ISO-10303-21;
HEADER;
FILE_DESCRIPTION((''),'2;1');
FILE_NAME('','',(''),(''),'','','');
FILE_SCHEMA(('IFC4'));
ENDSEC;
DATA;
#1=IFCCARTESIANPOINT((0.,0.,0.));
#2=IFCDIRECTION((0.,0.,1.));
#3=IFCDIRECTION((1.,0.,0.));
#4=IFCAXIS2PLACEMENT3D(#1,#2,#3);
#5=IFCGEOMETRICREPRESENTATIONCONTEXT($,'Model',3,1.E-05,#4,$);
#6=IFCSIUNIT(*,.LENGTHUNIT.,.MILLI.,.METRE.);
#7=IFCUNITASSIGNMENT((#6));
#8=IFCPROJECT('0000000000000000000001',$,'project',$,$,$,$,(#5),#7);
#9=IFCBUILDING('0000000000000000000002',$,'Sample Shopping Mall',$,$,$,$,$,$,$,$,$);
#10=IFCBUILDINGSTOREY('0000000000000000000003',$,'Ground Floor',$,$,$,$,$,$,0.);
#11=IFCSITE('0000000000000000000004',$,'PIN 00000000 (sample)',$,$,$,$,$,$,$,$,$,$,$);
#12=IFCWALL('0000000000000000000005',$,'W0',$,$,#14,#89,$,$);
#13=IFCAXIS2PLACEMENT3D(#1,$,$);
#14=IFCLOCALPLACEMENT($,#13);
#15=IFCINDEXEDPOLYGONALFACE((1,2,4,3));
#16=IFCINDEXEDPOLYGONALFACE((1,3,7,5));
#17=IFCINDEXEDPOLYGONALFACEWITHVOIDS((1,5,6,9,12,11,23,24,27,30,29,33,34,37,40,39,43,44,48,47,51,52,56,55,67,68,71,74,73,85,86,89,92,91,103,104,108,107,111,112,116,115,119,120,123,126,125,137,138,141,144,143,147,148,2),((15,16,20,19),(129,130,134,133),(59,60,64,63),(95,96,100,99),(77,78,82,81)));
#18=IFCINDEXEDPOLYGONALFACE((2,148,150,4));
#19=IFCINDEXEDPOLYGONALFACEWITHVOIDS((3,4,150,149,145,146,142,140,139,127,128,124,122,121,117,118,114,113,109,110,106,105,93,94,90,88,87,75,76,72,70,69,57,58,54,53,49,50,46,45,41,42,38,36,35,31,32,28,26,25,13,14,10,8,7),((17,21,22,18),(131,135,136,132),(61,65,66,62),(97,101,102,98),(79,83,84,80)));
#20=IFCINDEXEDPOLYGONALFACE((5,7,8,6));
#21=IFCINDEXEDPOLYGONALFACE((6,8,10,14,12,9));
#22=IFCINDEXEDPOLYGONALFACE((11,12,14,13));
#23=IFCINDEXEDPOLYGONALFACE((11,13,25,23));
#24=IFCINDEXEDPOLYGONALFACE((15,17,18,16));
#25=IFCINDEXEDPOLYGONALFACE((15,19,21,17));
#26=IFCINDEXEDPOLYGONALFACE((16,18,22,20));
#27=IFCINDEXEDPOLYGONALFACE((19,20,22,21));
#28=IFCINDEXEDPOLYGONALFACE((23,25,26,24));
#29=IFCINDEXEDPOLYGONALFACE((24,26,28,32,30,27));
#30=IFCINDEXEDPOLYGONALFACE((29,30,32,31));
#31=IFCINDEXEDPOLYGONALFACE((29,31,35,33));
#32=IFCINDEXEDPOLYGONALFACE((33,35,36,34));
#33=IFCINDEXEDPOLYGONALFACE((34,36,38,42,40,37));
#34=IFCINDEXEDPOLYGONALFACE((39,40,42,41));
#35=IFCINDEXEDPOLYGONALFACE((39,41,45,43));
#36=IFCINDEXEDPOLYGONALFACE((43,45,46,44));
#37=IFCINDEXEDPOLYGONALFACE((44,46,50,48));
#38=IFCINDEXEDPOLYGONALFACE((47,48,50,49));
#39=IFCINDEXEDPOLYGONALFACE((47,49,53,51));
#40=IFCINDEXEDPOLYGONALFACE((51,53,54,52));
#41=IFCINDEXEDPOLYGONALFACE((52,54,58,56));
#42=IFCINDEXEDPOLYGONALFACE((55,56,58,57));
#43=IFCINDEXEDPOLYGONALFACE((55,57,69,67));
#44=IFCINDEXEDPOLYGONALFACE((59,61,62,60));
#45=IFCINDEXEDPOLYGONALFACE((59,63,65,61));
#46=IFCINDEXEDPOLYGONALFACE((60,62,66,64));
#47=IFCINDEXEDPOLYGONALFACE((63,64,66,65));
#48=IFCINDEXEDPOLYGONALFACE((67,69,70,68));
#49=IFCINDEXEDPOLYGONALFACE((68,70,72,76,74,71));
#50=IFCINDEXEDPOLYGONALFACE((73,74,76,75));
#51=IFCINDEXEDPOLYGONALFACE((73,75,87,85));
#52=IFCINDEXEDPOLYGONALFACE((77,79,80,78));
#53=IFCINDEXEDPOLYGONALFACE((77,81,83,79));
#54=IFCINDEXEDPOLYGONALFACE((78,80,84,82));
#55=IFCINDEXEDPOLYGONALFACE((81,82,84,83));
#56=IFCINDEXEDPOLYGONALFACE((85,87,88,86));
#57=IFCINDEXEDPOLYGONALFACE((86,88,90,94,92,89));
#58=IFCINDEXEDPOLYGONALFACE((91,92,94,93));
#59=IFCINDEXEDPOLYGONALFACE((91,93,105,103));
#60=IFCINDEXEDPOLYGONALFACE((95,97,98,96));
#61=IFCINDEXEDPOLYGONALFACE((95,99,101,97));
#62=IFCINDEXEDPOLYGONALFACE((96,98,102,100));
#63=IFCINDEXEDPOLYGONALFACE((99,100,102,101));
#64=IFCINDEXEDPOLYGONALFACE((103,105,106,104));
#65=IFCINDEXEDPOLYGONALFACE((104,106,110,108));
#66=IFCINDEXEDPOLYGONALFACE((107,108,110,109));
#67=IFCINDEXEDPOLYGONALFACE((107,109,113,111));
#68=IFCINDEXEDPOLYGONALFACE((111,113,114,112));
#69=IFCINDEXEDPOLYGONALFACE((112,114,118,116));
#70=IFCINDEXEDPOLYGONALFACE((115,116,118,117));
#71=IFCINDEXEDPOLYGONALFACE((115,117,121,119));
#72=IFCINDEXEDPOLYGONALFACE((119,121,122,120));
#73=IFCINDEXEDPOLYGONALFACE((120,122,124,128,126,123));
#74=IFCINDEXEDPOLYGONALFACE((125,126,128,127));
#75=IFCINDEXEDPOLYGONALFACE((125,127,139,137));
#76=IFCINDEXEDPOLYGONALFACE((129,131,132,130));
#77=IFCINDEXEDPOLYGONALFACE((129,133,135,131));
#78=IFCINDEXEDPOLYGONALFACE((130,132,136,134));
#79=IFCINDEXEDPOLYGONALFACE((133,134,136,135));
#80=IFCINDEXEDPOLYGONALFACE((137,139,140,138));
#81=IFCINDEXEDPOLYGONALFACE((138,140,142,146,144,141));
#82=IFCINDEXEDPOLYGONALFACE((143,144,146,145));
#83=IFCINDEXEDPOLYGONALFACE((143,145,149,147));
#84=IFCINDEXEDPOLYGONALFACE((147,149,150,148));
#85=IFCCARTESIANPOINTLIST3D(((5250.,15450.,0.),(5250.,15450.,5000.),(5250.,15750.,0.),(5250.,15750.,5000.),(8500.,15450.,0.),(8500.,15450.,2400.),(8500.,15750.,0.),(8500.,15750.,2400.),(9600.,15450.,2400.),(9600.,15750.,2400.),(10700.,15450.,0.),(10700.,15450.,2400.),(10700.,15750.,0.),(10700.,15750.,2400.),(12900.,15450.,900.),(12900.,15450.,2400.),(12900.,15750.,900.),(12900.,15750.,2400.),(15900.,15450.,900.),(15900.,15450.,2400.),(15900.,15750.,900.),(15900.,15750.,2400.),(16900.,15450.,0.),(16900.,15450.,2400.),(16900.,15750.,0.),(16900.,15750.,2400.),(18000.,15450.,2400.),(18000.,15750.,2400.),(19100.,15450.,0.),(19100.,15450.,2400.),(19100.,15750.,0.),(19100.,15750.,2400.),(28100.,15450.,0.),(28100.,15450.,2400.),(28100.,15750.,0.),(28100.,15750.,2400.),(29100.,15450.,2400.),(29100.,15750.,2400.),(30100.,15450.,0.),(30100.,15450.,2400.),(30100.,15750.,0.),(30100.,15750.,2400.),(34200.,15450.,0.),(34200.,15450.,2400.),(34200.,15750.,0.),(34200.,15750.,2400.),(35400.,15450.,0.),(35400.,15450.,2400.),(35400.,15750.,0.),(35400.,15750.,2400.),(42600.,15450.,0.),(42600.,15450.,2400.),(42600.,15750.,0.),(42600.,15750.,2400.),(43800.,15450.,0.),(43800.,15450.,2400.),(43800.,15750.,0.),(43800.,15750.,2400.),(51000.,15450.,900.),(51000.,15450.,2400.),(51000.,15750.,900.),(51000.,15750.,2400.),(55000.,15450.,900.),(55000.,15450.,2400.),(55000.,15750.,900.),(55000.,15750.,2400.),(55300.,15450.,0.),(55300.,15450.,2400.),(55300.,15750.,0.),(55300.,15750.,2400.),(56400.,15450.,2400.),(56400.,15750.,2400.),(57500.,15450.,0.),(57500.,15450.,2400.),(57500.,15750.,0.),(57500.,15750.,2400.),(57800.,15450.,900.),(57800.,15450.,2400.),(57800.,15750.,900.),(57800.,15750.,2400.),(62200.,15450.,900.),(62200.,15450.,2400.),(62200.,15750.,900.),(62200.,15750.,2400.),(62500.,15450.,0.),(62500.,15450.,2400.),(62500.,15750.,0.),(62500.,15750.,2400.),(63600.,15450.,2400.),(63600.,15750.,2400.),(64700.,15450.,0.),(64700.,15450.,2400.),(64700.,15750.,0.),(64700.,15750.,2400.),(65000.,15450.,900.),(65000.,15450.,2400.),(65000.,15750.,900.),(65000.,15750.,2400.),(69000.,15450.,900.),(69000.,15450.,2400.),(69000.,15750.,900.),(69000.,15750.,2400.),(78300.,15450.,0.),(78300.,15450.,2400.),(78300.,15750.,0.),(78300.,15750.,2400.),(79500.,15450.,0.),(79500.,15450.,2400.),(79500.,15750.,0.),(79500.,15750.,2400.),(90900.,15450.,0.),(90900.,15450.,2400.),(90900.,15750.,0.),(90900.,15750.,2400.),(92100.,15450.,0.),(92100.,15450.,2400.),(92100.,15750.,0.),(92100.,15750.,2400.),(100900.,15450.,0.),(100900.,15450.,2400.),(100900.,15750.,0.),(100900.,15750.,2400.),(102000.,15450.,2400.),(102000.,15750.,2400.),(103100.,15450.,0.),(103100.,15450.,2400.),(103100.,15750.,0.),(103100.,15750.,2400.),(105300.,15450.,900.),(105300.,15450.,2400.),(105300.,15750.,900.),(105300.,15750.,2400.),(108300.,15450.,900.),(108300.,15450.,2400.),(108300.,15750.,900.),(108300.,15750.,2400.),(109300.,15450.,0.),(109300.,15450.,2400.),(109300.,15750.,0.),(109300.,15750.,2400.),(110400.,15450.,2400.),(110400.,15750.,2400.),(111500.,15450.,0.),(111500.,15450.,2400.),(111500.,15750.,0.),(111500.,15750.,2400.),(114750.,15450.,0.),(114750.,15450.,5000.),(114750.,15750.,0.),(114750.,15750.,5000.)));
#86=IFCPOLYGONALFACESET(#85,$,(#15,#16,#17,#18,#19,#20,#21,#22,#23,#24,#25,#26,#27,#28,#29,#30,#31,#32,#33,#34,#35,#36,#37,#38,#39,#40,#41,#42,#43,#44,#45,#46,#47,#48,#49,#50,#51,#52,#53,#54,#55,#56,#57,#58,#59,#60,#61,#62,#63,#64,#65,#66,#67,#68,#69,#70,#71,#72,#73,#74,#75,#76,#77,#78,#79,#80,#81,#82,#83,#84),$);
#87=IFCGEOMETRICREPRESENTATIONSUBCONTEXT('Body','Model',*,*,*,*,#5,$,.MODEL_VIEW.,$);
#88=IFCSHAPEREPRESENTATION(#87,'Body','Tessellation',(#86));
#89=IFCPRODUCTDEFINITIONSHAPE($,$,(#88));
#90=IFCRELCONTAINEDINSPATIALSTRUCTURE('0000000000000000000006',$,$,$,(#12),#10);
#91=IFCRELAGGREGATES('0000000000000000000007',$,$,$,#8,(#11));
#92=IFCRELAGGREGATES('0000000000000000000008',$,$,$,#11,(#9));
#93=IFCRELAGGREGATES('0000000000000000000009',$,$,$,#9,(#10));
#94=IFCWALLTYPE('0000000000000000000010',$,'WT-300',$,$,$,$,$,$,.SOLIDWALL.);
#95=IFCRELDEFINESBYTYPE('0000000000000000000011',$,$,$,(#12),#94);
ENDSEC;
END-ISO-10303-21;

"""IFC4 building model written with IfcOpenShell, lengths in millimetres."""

from ifc_helpers import new_model, si_unit, frame, origin_with_axes, place, context, subcontext, project, spatial, indexed_curve, outline, extrude, type_object, element, save


model = new_model("IFC4")

# Units and contexts
model_context = context("Model", 3, precision=1e-05, world=origin_with_axes())
body_context = subcontext(model_context, "Body", "Model", "MODEL_VIEW")
ifc_project = project(units=[si_unit("LENGTHUNIT", "METRE", prefix="MILLI")], contexts=[model_context])

# Site, building, storey
site = spatial("IfcSite", under=ifc_project, Name="PIN 00000000 (sample)")
building = spatial("IfcBuilding", under=site, Name="Sample Shopping Mall")
storey = spatial("IfcBuildingStorey", under=building, Name="Ground Floor", Elevation=0.0)

# Wall, openings
wall_type = type_object("IfcWallType", Name="WT-300", PredefinedType="SOLIDWALL")
wall_1_placement = place(None, frame((5250.0, 15450.0, 0.0), z_axis=(0.0, 0.0, 1.0), x_axis=(1.0, 0.0, 0.0)))
wall_1 = element("IfcWall", 1, at=wall_1_placement, inside=storey, type_object=wall_type, Name="W0", context=body_context, shape_type="SweptSolid", body=[
    extrude(outline(indexed_curve([(0.0, 0.0), (0.0, 300.0), (109500.0, 300.0), (109500.0, 0.0), (0.0, 0.0)], self_intersect=False)), origin_with_axes(), (0.0, 0.0, 1.0), 5000.0),
])
opening_1_placement = place(wall_1_placement, frame((50050.0, -100.0, 0.0), z_axis=(0.0, 0.0, 1.0), x_axis=(1.0, 0.0, 0.0)))
element("IfcOpeningElement", 2, at=opening_1_placement, cuts=wall_1, context=body_context, shape_type="SweptSolid", body=[
    extrude(outline(indexed_curve([(0.0, 0.0), (0.0, 500.0), (1100.0, 500.0), (1100.0, 0.0), (0.0, 0.0)], self_intersect=False)), origin_with_axes(), (0.0, 0.0, 1.0), 2400.0),
])
opening_2_placement = place(wall_1_placement, frame((51150.0, -100.0, 0.0), z_axis=(0.0, 0.0, 1.0), x_axis=(1.0, 0.0, 0.0)))
element("IfcOpeningElement", 3, at=opening_2_placement, cuts=wall_1, context=body_context, shape_type="SweptSolid", body=[
    extrude(outline(indexed_curve([(0.0, 0.0), (0.0, 500.0), (1100.0, 500.0), (1100.0, 0.0), (0.0, 0.0)], self_intersect=False)), origin_with_axes(), (0.0, 0.0, 1.0), 2400.0),
])
opening_3_placement = place(wall_1_placement, frame((57250.0, -100.0, 0.0), z_axis=(0.0, 0.0, 1.0), x_axis=(1.0, 0.0, 0.0)))
element("IfcOpeningElement", 4, at=opening_3_placement, cuts=wall_1, context=body_context, shape_type="SweptSolid", body=[
    extrude(outline(indexed_curve([(0.0, 0.0), (0.0, 500.0), (1100.0, 500.0), (1100.0, 0.0), (0.0, 0.0)], self_intersect=False)), origin_with_axes(), (0.0, 0.0, 1.0), 2400.0),
])
opening_4_placement = place(wall_1_placement, frame((58350.0, -100.0, 0.0), z_axis=(0.0, 0.0, 1.0), x_axis=(1.0, 0.0, 0.0)))
element("IfcOpeningElement", 5, at=opening_4_placement, cuts=wall_1, context=body_context, shape_type="SweptSolid", body=[
    extrude(outline(indexed_curve([(0.0, 0.0), (0.0, 500.0), (1100.0, 500.0), (1100.0, 0.0), (0.0, 0.0)], self_intersect=False)), origin_with_axes(), (0.0, 0.0, 1.0), 2400.0),
])
opening_5_placement = place(wall_1_placement, frame((3250.0, -100.0, 0.0), z_axis=(0.0, 0.0, 1.0), x_axis=(1.0, 0.0, 0.0)))
element("IfcOpeningElement", 6, at=opening_5_placement, cuts=wall_1, context=body_context, shape_type="SweptSolid", body=[
    extrude(outline(indexed_curve([(0.0, 0.0), (0.0, 500.0), (1100.0, 500.0), (1100.0, 0.0), (0.0, 0.0)], self_intersect=False)), origin_with_axes(), (0.0, 0.0, 1.0), 2400.0),
])
opening_6_placement = place(wall_1_placement, frame((4350.0, -100.0, 0.0), z_axis=(0.0, 0.0, 1.0), x_axis=(1.0, 0.0, 0.0)))
element("IfcOpeningElement", 7, at=opening_6_placement, cuts=wall_1, context=body_context, shape_type="SweptSolid", body=[
    extrude(outline(indexed_curve([(0.0, 0.0), (0.0, 500.0), (1100.0, 500.0), (1100.0, 0.0), (0.0, 0.0)], self_intersect=False)), origin_with_axes(), (0.0, 0.0, 1.0), 2400.0),
])
opening_7_placement = place(wall_1_placement, frame((11650.0, -100.0, 0.0), z_axis=(0.0, 0.0, 1.0), x_axis=(1.0, 0.0, 0.0)))
element("IfcOpeningElement", 8, at=opening_7_placement, cuts=wall_1, context=body_context, shape_type="SweptSolid", body=[
    extrude(outline(indexed_curve([(0.0, 0.0), (0.0, 500.0), (1100.0, 500.0), (1100.0, 0.0), (0.0, 0.0)], self_intersect=False)), origin_with_axes(), (0.0, 0.0, 1.0), 2400.0),
])
opening_8_placement = place(wall_1_placement, frame((12750.0, -100.0, 0.0), z_axis=(0.0, 0.0, 1.0), x_axis=(1.0, 0.0, 0.0)))
element("IfcOpeningElement", 9, at=opening_8_placement, cuts=wall_1, context=body_context, shape_type="SweptSolid", body=[
    extrude(outline(indexed_curve([(0.0, 0.0), (0.0, 500.0), (1100.0, 500.0), (1100.0, 0.0), (0.0, 0.0)], self_intersect=False)), origin_with_axes(), (0.0, 0.0, 1.0), 2400.0),
])
opening_9_placement = place(wall_1_placement, frame((95650.0, -100.0, 0.0), z_axis=(0.0, 0.0, 1.0), x_axis=(1.0, 0.0, 0.0)))
element("IfcOpeningElement", 10, at=opening_9_placement, cuts=wall_1, context=body_context, shape_type="SweptSolid", body=[
    extrude(outline(indexed_curve([(0.0, 0.0), (0.0, 500.0), (1100.0, 500.0), (1100.0, 0.0), (0.0, 0.0)], self_intersect=False)), origin_with_axes(), (0.0, 0.0, 1.0), 2400.0),
])
opening_10_placement = place(wall_1_placement, frame((96750.0, -100.0, 0.0), z_axis=(0.0, 0.0, 1.0), x_axis=(1.0, 0.0, 0.0)))
element("IfcOpeningElement", 11, at=opening_10_placement, cuts=wall_1, context=body_context, shape_type="SweptSolid", body=[
    extrude(outline(indexed_curve([(0.0, 0.0), (0.0, 500.0), (1100.0, 500.0), (1100.0, 0.0), (0.0, 0.0)], self_intersect=False)), origin_with_axes(), (0.0, 0.0, 1.0), 2400.0),
])
opening_11_placement = place(wall_1_placement, frame((104050.0, -100.0, 0.0), z_axis=(0.0, 0.0, 1.0), x_axis=(1.0, 0.0, 0.0)))
element("IfcOpeningElement", 12, at=opening_11_placement, cuts=wall_1, context=body_context, shape_type="SweptSolid", body=[
    extrude(outline(indexed_curve([(0.0, 0.0), (0.0, 500.0), (1100.0, 500.0), (1100.0, 0.0), (0.0, 0.0)], self_intersect=False)), origin_with_axes(), (0.0, 0.0, 1.0), 2400.0),
])
opening_12_placement = place(wall_1_placement, frame((105150.0, -100.0, 0.0), z_axis=(0.0, 0.0, 1.0), x_axis=(1.0, 0.0, 0.0)))
element("IfcOpeningElement", 13, at=opening_12_placement, cuts=wall_1, context=body_context, shape_type="SweptSolid", body=[
    extrude(outline(indexed_curve([(0.0, 0.0), (0.0, 500.0), (1100.0, 500.0), (1100.0, 0.0), (0.0, 0.0)], self_intersect=False)), origin_with_axes(), (0.0, 0.0, 1.0), 2400.0),
])
opening_13_placement = place(wall_1_placement, frame((28950.0, -100.0, 0.0), z_axis=(0.0, 0.0, 1.0), x_axis=(1.0, 0.0, 0.0)))
element("IfcOpeningElement", 14, at=opening_13_placement, cuts=wall_1, context=body_context, shape_type="SweptSolid", body=[
    extrude(outline(indexed_curve([(0.0, 0.0), (0.0, 500.0), (1200.0, 500.0), (1200.0, 0.0), (0.0, 0.0)], self_intersect=False)), origin_with_axes(), (0.0, 0.0, 1.0), 2400.0),
])
opening_14_placement = place(wall_1_placement, frame((37350.0, -100.0, 0.0), z_axis=(0.0, 0.0, 1.0), x_axis=(1.0, 0.0, 0.0)))
element("IfcOpeningElement", 15, at=opening_14_placement, cuts=wall_1, context=body_context, shape_type="SweptSolid", body=[
    extrude(outline(indexed_curve([(0.0, 0.0), (0.0, 500.0), (1200.0, 500.0), (1200.0, 0.0), (0.0, 0.0)], self_intersect=False)), origin_with_axes(), (0.0, 0.0, 1.0), 2400.0),
])
opening_15_placement = place(wall_1_placement, frame((73050.0, -100.0, 0.0), z_axis=(0.0, 0.0, 1.0), x_axis=(1.0, 0.0, 0.0)))
element("IfcOpeningElement", 16, at=opening_15_placement, cuts=wall_1, context=body_context, shape_type="SweptSolid", body=[
    extrude(outline(indexed_curve([(0.0, 0.0), (0.0, 500.0), (1200.0, 500.0), (1200.0, 0.0), (0.0, 0.0)], self_intersect=False)), origin_with_axes(), (0.0, 0.0, 1.0), 2400.0),
])
opening_16_placement = place(wall_1_placement, frame((85650.0, -100.0, 0.0), z_axis=(0.0, 0.0, 1.0), x_axis=(1.0, 0.0, 0.0)))
element("IfcOpeningElement", 17, at=opening_16_placement, cuts=wall_1, context=body_context, shape_type="SweptSolid", body=[
    extrude(outline(indexed_curve([(0.0, 0.0), (0.0, 500.0), (1200.0, 500.0), (1200.0, 0.0), (0.0, 0.0)], self_intersect=False)), origin_with_axes(), (0.0, 0.0, 1.0), 2400.0),
])
opening_17_placement = place(wall_1_placement, frame((22850.0, -100.0, 0.0), z_axis=(0.0, 0.0, 1.0), x_axis=(1.0, 0.0, 0.0)))
element("IfcOpeningElement", 18, at=opening_17_placement, cuts=wall_1, context=body_context, shape_type="SweptSolid", body=[
    extrude(outline(indexed_curve([(0.0, 0.0), (0.0, 500.0), (1000.0, 500.0), (1000.0, 0.0), (0.0, 0.0)], self_intersect=False)), origin_with_axes(), (0.0, 0.0, 1.0), 2400.0),
])
opening_18_placement = place(wall_1_placement, frame((23850.0, -100.0, 0.0), z_axis=(0.0, 0.0, 1.0), x_axis=(1.0, 0.0, 0.0)))
element("IfcOpeningElement", 19, at=opening_18_placement, cuts=wall_1, context=body_context, shape_type="SweptSolid", body=[
    extrude(outline(indexed_curve([(0.0, 0.0), (0.0, 500.0), (1000.0, 500.0), (1000.0, 0.0), (0.0, 0.0)], self_intersect=False)), origin_with_axes(), (0.0, 0.0, 1.0), 2400.0),
])
opening_19_placement = place(wall_1_placement, frame((45750.0, -100.0, 900.0), z_axis=(0.0, 0.0, 1.0), x_axis=(1.0, 0.0, 0.0)))
element("IfcOpeningElement", 20, at=opening_19_placement, cuts=wall_1, context=body_context, shape_type="SweptSolid", body=[
    extrude(outline(indexed_curve([(0.0, 0.0), (0.0, 500.0), (4000.0, 500.0), (4000.0, 0.0), (0.0, 0.0)], self_intersect=False)), origin_with_axes(), (0.0, 0.0, 1.0), 1500.0),
])
opening_20_placement = place(wall_1_placement, frame((52550.0, -100.0, 900.0), z_axis=(0.0, 0.0, 1.0), x_axis=(1.0, 0.0, 0.0)))
element("IfcOpeningElement", 21, at=opening_20_placement, cuts=wall_1, context=body_context, shape_type="SweptSolid", body=[
    extrude(outline(indexed_curve([(0.0, 0.0), (0.0, 500.0), (4400.0, 500.0), (4400.0, 0.0), (0.0, 0.0)], self_intersect=False)), origin_with_axes(), (0.0, 0.0, 1.0), 1500.0),
])
opening_21_placement = place(wall_1_placement, frame((59750.0, -100.0, 900.0), z_axis=(0.0, 0.0, 1.0), x_axis=(1.0, 0.0, 0.0)))
element("IfcOpeningElement", 22, at=opening_21_placement, cuts=wall_1, context=body_context, shape_type="SweptSolid", body=[
    extrude(outline(indexed_curve([(0.0, 0.0), (0.0, 500.0), (4000.0, 500.0), (4000.0, 0.0), (0.0, 0.0)], self_intersect=False)), origin_with_axes(), (0.0, 0.0, 1.0), 1500.0),
])
opening_22_placement = place(wall_1_placement, frame((7650.0, -100.0, 900.0), z_axis=(0.0, 0.0, 1.0), x_axis=(1.0, 0.0, 0.0)))
element("IfcOpeningElement", 23, at=opening_22_placement, cuts=wall_1, context=body_context, shape_type="SweptSolid", body=[
    extrude(outline(indexed_curve([(0.0, 0.0), (0.0, 500.0), (3000.0, 500.0), (3000.0, 0.0), (0.0, 0.0)], self_intersect=False)), origin_with_axes(), (0.0, 0.0, 1.0), 1500.0),
])
opening_23_placement = place(wall_1_placement, frame((100050.0, -100.0, 900.0), z_axis=(0.0, 0.0, 1.0), x_axis=(1.0, 0.0, 0.0)))
element("IfcOpeningElement", 24, at=opening_23_placement, cuts=wall_1, context=body_context, shape_type="SweptSolid", body=[
    extrude(outline(indexed_curve([(0.0, 0.0), (0.0, 500.0), (3000.0, 500.0), (3000.0, 0.0), (0.0, 0.0)], self_intersect=False)), origin_with_axes(), (0.0, 0.0, 1.0), 1500.0),
])

save(model, "model.ifc")
